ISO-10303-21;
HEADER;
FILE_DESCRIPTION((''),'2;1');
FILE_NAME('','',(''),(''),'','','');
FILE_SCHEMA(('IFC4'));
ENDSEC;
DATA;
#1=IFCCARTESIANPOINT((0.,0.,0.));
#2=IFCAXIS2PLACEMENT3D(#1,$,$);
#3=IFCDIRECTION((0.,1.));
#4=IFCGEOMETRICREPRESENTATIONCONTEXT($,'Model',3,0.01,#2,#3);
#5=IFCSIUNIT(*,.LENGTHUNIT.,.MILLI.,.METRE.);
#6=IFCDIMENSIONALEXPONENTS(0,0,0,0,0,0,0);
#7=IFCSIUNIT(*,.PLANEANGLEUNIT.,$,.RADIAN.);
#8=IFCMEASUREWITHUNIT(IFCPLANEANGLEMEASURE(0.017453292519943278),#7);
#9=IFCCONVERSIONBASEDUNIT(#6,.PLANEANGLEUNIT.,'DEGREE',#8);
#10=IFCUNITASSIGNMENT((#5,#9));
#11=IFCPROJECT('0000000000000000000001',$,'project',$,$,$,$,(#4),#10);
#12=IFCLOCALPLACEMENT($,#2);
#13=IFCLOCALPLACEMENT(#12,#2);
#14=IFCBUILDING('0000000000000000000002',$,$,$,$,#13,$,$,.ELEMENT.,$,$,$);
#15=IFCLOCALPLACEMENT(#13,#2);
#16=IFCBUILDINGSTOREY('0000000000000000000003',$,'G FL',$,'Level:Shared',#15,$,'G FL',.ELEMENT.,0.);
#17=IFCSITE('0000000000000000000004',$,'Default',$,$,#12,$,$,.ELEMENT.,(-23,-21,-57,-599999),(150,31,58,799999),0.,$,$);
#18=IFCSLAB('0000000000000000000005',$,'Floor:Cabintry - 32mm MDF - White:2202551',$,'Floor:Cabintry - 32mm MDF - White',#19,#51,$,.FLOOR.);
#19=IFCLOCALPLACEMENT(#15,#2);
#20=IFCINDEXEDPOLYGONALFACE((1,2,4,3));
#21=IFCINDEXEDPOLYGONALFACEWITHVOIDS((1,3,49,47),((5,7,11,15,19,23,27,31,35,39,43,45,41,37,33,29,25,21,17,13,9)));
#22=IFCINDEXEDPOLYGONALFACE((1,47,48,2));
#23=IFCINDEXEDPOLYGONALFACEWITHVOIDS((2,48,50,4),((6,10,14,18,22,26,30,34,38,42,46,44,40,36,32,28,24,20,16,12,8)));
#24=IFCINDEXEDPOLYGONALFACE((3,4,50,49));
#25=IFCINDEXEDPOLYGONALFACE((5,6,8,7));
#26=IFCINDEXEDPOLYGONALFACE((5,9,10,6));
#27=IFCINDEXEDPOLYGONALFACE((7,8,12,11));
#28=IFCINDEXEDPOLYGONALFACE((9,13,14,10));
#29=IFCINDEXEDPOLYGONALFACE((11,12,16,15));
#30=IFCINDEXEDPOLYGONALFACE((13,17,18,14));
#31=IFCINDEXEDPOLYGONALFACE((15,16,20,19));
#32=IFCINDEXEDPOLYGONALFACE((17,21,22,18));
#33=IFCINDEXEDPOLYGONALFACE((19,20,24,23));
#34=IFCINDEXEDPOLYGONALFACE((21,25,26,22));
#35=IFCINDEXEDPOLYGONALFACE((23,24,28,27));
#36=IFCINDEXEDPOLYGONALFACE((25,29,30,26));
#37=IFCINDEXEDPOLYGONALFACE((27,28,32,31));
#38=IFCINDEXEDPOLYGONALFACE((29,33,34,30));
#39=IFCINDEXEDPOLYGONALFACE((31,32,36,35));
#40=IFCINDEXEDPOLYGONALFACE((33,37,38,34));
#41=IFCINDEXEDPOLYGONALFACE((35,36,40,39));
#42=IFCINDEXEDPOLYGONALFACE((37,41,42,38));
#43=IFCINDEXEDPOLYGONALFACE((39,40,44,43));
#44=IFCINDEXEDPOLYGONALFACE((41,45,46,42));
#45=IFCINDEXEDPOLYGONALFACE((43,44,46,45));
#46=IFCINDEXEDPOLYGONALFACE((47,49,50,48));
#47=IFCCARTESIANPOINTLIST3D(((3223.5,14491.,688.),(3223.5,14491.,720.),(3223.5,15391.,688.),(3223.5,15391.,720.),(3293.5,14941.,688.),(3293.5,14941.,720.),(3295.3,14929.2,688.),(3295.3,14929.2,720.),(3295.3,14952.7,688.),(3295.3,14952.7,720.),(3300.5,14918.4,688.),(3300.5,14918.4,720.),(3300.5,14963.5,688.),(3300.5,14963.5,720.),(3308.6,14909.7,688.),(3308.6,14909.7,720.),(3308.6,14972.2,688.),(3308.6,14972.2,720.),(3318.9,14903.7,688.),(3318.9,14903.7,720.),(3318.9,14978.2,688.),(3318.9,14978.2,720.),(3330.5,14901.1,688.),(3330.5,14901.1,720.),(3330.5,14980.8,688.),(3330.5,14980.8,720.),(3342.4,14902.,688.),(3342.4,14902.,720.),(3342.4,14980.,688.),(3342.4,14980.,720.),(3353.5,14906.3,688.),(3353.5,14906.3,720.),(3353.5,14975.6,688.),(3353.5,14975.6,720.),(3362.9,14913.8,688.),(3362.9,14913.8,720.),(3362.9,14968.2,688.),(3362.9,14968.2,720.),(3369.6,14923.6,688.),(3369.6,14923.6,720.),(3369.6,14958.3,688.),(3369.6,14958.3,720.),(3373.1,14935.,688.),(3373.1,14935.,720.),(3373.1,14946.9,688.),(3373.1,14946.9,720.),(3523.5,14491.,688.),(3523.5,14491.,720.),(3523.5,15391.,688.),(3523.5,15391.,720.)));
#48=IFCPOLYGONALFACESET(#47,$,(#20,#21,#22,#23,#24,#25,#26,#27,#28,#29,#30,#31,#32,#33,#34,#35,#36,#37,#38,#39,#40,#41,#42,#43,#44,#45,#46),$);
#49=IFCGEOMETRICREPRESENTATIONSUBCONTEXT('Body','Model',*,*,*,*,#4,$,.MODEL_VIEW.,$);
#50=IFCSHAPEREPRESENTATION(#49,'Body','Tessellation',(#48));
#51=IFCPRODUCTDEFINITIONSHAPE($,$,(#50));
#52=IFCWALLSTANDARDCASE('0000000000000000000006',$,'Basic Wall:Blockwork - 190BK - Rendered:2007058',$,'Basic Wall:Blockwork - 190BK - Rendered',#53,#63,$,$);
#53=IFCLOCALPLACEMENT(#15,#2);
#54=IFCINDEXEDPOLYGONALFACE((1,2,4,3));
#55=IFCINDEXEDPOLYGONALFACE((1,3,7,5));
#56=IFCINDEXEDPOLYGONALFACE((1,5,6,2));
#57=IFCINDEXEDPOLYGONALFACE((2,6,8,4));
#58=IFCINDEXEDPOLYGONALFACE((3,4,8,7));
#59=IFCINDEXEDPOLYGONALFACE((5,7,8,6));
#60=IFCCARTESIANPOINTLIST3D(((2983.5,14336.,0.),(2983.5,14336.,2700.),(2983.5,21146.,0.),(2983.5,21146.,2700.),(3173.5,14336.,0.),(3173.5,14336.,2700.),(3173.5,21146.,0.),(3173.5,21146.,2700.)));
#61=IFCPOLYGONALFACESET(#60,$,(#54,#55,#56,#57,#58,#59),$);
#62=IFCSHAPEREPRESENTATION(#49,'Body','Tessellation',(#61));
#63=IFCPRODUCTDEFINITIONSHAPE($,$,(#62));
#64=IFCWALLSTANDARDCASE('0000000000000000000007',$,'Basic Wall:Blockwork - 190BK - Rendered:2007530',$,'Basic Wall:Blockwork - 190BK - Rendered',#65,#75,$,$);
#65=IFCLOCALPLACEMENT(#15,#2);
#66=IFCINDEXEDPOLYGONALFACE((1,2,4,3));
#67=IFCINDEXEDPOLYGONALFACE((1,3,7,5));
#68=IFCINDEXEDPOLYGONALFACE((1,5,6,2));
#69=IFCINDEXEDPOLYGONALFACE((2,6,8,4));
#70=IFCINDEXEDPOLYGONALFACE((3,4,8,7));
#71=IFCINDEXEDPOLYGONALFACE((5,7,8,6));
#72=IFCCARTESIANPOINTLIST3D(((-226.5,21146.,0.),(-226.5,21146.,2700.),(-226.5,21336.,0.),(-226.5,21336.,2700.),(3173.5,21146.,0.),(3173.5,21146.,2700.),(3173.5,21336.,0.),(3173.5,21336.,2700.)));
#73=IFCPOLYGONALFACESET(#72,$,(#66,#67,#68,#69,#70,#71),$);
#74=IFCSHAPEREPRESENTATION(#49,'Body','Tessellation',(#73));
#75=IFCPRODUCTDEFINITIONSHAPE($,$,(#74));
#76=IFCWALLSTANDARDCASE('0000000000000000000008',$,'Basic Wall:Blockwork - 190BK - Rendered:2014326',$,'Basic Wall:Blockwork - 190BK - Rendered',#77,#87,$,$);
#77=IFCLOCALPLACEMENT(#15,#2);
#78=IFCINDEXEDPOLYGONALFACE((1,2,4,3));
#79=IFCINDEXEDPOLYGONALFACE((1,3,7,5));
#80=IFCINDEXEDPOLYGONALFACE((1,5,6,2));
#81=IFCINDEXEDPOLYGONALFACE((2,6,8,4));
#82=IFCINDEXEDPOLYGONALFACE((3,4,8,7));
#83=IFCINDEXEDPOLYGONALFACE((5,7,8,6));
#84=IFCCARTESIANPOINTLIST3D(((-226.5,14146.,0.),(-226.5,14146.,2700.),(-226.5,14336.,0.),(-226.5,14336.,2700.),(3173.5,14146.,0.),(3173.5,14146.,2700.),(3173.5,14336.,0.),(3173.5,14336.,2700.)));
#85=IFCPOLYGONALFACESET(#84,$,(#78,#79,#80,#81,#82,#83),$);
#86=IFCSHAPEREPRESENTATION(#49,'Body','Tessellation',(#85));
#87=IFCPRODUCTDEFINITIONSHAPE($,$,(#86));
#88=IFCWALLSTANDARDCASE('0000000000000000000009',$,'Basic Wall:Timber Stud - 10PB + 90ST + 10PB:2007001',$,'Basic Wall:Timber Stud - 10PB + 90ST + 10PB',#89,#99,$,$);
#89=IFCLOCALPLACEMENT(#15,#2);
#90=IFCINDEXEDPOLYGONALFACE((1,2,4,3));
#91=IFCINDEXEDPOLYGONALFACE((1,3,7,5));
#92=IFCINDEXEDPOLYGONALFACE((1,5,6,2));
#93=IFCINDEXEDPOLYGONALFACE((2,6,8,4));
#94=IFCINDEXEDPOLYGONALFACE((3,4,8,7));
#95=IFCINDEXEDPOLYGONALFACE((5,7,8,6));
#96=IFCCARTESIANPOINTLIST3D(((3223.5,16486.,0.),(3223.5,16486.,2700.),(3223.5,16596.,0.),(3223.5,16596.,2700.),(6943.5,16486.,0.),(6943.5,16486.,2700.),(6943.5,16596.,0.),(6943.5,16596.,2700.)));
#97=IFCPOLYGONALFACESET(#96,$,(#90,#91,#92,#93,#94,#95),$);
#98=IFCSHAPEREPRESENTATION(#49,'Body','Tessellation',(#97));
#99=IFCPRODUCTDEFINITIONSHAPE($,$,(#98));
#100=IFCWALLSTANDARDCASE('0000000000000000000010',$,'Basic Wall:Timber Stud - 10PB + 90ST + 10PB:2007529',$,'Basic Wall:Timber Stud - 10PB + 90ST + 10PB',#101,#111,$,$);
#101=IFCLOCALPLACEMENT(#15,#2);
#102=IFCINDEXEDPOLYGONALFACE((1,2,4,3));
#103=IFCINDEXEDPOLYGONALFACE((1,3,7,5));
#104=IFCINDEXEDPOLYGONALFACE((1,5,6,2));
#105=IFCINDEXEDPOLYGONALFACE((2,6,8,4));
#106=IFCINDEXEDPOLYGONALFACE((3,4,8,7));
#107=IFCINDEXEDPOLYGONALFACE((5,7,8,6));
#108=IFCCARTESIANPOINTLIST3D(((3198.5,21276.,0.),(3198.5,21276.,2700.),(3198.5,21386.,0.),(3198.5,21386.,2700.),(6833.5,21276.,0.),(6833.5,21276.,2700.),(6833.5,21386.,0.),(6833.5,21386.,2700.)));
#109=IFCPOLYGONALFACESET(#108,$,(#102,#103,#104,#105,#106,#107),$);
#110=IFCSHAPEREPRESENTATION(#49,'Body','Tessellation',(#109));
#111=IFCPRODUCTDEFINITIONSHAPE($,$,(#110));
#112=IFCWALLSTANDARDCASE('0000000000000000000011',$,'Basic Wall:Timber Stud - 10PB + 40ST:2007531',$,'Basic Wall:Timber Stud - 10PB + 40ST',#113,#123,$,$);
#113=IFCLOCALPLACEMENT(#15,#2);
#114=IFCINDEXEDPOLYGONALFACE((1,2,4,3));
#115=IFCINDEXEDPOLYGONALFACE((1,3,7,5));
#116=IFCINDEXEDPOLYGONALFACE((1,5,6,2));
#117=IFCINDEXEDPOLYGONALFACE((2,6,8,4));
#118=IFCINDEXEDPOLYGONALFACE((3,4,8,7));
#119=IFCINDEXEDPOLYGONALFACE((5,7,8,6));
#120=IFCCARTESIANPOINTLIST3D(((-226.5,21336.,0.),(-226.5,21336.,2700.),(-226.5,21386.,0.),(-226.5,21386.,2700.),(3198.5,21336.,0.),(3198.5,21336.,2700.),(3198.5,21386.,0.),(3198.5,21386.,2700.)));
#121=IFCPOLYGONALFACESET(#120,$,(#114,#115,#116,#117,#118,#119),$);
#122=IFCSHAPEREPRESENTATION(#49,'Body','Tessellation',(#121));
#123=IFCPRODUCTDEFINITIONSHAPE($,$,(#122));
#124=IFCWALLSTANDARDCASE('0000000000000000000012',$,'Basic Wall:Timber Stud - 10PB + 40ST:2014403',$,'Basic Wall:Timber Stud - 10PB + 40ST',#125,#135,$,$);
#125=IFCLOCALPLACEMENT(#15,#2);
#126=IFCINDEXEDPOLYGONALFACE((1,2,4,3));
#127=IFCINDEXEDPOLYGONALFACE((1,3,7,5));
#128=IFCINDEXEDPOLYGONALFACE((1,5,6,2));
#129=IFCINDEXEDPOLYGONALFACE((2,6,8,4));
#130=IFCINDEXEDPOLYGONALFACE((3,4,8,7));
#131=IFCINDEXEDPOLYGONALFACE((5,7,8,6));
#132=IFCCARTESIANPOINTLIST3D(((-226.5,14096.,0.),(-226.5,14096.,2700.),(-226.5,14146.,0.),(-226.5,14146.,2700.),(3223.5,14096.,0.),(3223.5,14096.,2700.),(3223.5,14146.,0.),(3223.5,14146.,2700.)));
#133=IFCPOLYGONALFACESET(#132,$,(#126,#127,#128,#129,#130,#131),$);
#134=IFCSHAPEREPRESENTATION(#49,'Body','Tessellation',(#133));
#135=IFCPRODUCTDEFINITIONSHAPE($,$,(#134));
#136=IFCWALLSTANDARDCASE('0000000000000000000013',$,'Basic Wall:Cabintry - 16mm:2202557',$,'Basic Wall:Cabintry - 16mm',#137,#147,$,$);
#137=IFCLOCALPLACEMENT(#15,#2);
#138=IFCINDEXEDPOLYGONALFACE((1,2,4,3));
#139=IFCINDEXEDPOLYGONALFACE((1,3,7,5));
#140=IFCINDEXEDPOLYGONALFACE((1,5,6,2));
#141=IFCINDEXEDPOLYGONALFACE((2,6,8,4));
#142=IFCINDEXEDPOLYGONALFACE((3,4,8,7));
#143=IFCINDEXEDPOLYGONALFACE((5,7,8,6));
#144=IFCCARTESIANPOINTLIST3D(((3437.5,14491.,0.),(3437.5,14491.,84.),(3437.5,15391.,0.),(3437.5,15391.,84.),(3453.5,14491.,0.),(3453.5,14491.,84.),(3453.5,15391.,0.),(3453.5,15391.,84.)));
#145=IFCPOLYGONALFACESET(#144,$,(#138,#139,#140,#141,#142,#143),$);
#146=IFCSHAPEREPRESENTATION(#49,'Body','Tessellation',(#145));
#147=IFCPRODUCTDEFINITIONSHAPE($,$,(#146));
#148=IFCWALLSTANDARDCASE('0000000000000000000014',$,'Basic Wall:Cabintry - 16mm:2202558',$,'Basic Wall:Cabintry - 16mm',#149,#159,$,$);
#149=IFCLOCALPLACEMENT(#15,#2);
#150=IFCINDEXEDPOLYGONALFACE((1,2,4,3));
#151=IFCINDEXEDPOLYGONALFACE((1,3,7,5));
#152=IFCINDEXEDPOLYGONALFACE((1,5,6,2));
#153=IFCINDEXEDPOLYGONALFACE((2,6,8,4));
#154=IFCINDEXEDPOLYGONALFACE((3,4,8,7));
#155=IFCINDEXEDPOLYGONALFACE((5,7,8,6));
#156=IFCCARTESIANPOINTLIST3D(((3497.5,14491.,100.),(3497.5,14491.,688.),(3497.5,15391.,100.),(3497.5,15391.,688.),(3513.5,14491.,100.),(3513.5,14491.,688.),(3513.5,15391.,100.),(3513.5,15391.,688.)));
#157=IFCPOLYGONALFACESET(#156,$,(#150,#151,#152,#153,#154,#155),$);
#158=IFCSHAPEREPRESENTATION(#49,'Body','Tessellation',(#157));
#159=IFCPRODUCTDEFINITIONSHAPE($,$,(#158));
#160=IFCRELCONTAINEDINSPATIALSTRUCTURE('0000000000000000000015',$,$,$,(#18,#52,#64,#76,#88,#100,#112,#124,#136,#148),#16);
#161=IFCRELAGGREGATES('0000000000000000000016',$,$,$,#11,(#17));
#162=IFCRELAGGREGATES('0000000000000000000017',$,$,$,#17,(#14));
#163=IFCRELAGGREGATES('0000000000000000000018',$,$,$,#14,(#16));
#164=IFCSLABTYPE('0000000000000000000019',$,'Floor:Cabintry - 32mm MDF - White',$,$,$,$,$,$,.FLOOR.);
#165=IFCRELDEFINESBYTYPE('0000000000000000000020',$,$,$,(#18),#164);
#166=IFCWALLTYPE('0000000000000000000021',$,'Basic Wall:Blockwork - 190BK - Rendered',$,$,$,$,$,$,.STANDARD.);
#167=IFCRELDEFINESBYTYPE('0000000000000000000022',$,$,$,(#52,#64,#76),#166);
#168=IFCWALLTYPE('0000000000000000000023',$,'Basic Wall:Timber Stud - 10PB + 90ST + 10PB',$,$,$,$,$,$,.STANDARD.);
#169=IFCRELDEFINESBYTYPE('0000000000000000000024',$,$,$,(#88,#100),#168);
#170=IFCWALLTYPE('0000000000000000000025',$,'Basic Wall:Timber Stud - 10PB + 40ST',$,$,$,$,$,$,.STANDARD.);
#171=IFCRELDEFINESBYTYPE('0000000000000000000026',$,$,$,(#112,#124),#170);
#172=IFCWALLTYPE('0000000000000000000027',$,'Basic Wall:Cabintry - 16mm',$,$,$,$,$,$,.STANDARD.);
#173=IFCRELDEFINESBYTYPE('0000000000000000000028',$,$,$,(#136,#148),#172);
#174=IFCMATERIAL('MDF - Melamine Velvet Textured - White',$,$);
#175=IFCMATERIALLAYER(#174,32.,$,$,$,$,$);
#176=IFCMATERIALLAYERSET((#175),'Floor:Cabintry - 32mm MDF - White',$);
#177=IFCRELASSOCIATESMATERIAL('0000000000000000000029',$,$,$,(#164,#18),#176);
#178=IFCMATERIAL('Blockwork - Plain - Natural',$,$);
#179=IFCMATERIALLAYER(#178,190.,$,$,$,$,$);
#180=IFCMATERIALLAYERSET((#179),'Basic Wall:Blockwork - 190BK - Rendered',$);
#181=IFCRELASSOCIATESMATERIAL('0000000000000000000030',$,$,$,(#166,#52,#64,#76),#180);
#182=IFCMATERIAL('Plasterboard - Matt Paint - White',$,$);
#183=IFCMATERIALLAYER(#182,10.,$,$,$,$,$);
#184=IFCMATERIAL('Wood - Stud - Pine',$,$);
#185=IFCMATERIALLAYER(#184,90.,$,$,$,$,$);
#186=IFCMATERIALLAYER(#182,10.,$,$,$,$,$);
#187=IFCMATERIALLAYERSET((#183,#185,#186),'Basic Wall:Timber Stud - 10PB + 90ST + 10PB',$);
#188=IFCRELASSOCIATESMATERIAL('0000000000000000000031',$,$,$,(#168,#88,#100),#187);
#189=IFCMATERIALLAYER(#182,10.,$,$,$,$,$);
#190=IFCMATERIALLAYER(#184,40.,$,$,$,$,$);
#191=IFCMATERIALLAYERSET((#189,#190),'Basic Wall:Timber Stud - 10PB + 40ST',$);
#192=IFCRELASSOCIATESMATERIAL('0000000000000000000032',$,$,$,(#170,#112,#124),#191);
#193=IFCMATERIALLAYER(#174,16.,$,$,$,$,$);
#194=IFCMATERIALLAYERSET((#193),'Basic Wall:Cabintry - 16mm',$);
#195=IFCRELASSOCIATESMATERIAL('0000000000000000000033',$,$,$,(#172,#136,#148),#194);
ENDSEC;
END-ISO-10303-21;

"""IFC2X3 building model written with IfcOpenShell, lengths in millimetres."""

from ifc_helpers import new_model, entity, si_unit, converted_unit, direction, frame, frame_2d, origin, origin_2d_with_axis, place, context, subcontext, project, spatial, polyline, rectangle, circle, extrude, clip, bounded_halfspace, material, layer, layer_set, layer_usage, type_object, element, save


model = new_model("IFC2X3")

# Units and contexts
model_context = context("Model", 3, precision=0.01, world=origin(), true_north=direction((0.0, 1.0)))
body_context = subcontext(model_context, "Body", "Model", "MODEL_VIEW")
ifc_project = project(units=[si_unit("LENGTHUNIT", "METRE", prefix="MILLI"), converted_unit("PLANEANGLEUNIT", "DEGREE", entity("IfcPlaneAngleMeasure", 0.017453292519943278), si_unit("PLANEANGLEUNIT", "RADIAN"), dimensions=[0, 0, 0, 0, 0, 0, 0])], contexts=[model_context])

# Site, building, storey
site_placement = place(None, origin())
site = spatial("IfcSite", under=ifc_project, at=site_placement, Name="Default", CompositionType="ELEMENT", RefLatitude=(-23, -21, -57, -599999), RefLongitude=(150, 31, 58, 799999), RefElevation=0.0)
building_placement = place(site_placement, origin())
building = spatial("IfcBuilding", under=site, at=building_placement, CompositionType="ELEMENT")
storey_placement = place(building_placement, origin())
storey = spatial("IfcBuildingStorey", under=building, at=storey_placement, Name="G FL", ObjectType="Level:Shared", LongName="G FL", CompositionType="ELEMENT", Elevation=0.0)

# Slab, opening
ifc_material_1 = material(Name="MDF - Melamine Velvet Textured - White")
ifc_layer_1 = layer(ifc_material_1, 32.0)
ifc_layer_set_1 = layer_set([ifc_layer_1], Name="Floor:Cabintry - 32mm MDF - White")
ifc_layer_usage_1 = layer_usage(ifc_layer_set_1, "AXIS3", "POSITIVE", 0.0)
slab_type = type_object("IfcSlabType", Name="Floor:Cabintry - 32mm MDF - White", PredefinedType="FLOOR", material=ifc_layer_set_1)
slab_placement = place(storey_placement, frame((3223.5, 14491.0, 688.0)))
slab = element("IfcSlab", 1, at=slab_placement, inside=storey, type_object=slab_type, material=ifc_layer_usage_1, Name="Floor:Cabintry - 32mm MDF - White:2202551", ObjectType="Floor:Cabintry - 32mm MDF - White", PredefinedType="FLOOR", context=body_context, shape_type="SweptSolid", body=[
    extrude(rectangle(XDim=300.0, YDim=900.0, at=origin_2d_with_axis()), frame((150.0, 450.0, 32.0), z_axis=(0.0, 0.0, -1.0), x_axis=(-1.0, 0.0, 0.0)), (0.0, 0.0, 1.0), 32.0),
])
opening_1_placement = place(slab_placement, origin())
element("IfcOpeningElement", 2, at=opening_1_placement, cuts=slab, ObjectType="Opening", context=body_context, shape_type="SweptSolid", body=[
    extrude(circle(Radius=40.0, at=frame_2d((40.0, 0.0), x_axis=(1.0, 0.0))), frame((150.0, 450.0, 32.0), z_axis=(0.0, 0.0, -1.0), x_axis=(-1.0, 0.0, 0.0)), (0.0, 0.0, 1.0), 32.0),
])

# Walls
ifc_material_2 = material(Name="Blockwork - Plain - Natural")
ifc_layer_2 = layer(ifc_material_2, 190.0)
ifc_layer_set_2 = layer_set([ifc_layer_2], Name="Basic Wall:Blockwork - 190BK - Rendered")
ifc_layer_usage_2 = layer_usage(ifc_layer_set_2, "AXIS2", "NEGATIVE", 95.0)
wall_type_1 = type_object("IfcWallType", Name="Basic Wall:Blockwork - 190BK - Rendered", PredefinedType="STANDARD", material=ifc_layer_set_2)
wall_1_placement = place(storey_placement, frame((3078.5, 14336.0, 0.0), z_axis=(0.0, 0.0, 1.0), x_axis=(0.0, 1.0, 0.0)))
element("IfcWallStandardCase", 3, at=wall_1_placement, inside=storey, type_object=wall_type_1, material=ifc_layer_usage_2, Name="Basic Wall:Blockwork - 190BK - Rendered:2007058", ObjectType="Basic Wall:Blockwork - 190BK - Rendered", context=body_context, shape_type="SweptSolid", body=[
    extrude(rectangle(XDim=6810.0, YDim=190.0, at=frame_2d((3405.0, 0.0), x_axis=(-1.0, 0.0))), origin(), (0.0, 0.0, 1.0), 2700.0),
])
ifc_layer_usage_3 = layer_usage(ifc_layer_set_2, "AXIS2", "NEGATIVE", 95.0)
wall_2_placement = place(storey_placement, frame((3173.5, 21241.0, 0.0), z_axis=(0.0, 0.0, 1.0), x_axis=(-1.0, 0.0, 0.0)))
element("IfcWallStandardCase", 4, at=wall_2_placement, inside=storey, type_object=wall_type_1, material=ifc_layer_usage_3, Name="Basic Wall:Blockwork - 190BK - Rendered:2007530", ObjectType="Basic Wall:Blockwork - 190BK - Rendered", context=body_context, shape_type="SweptSolid", body=[
    extrude(rectangle(XDim=3400.0, YDim=190.0, at=frame_2d((1700.0, 0.0), x_axis=(-1.0, 0.0))), origin(), (0.0, 0.0, 1.0), 2700.0),
])
ifc_layer_usage_4 = layer_usage(ifc_layer_set_2, "AXIS2", "NEGATIVE", 95.0)
wall_3_placement = place(storey_placement, frame((-226.5, 14241.0, 0.0)))
element("IfcWallStandardCase", 5, at=wall_3_placement, inside=storey, type_object=wall_type_1, material=ifc_layer_usage_4, Name="Basic Wall:Blockwork - 190BK - Rendered:2014326", ObjectType="Basic Wall:Blockwork - 190BK - Rendered", context=body_context, shape_type="SweptSolid", body=[
    extrude(rectangle(XDim=3400.0, YDim=190.0, at=frame_2d((1700.0, 0.0), x_axis=(-1.0, 0.0))), origin(), (0.0, 0.0, 1.0), 2700.0),
])
ifc_material_3 = material(Name="Plasterboard - Matt Paint - White")
ifc_layer_3 = layer(ifc_material_3, 10.0)
ifc_material_4 = material(Name="Wood - Stud - Pine")
ifc_layer_4 = layer(ifc_material_4, 90.0)
ifc_layer_5 = layer(ifc_material_3, 10.0)
ifc_layer_set_3 = layer_set([ifc_layer_3, ifc_layer_4, ifc_layer_5], Name="Basic Wall:Timber Stud - 10PB + 90ST + 10PB")
ifc_layer_usage_5 = layer_usage(ifc_layer_set_3, "AXIS2", "NEGATIVE", 55.0)
wall_type_2 = type_object("IfcWallType", Name="Basic Wall:Timber Stud - 10PB + 90ST + 10PB", PredefinedType="STANDARD", material=ifc_layer_set_3)
wall_4_placement = place(storey_placement, frame((3223.5, 16541.0, 0.0)))
element("IfcWallStandardCase", 6, at=wall_4_placement, inside=storey, type_object=wall_type_2, material=ifc_layer_usage_5, Name="Basic Wall:Timber Stud - 10PB + 90ST + 10PB:2007001", ObjectType="Basic Wall:Timber Stud - 10PB + 90ST + 10PB", context=body_context, shape_type="SweptSolid", body=[
    extrude(rectangle(XDim=3720.0, YDim=110.0, at=frame_2d((1860.0, 0.0), x_axis=(-1.0, 0.0))), origin(), (0.0, 0.0, 1.0), 2700.0),
])
ifc_layer_usage_6 = layer_usage(ifc_layer_set_3, "AXIS2", "NEGATIVE", 55.0)
wall_5_placement = place(storey_placement, frame((6833.5, 21331.0, 0.0), z_axis=(0.0, 0.0, 1.0), x_axis=(-1.0, 0.0, 0.0)))
element("IfcWallStandardCase", 7, at=wall_5_placement, inside=storey, type_object=wall_type_2, material=ifc_layer_usage_6, Name="Basic Wall:Timber Stud - 10PB + 90ST + 10PB:2007529", ObjectType="Basic Wall:Timber Stud - 10PB + 90ST + 10PB", context=body_context, shape_type="SweptSolid", body=[
    extrude(rectangle(XDim=3635.0, YDim=110.0, at=frame_2d((1817.5, 0.0), x_axis=(-1.0, 0.0))), origin(), (0.0, 0.0, 1.0), 2700.0),
])
ifc_layer_6 = layer(ifc_material_3, 10.0)
ifc_layer_7 = layer(ifc_material_4, 40.0)
ifc_layer_set_4 = layer_set([ifc_layer_6, ifc_layer_7], Name="Basic Wall:Timber Stud - 10PB + 40ST")
wall_type_3 = type_object("IfcWallType", Name="Basic Wall:Timber Stud - 10PB + 40ST", PredefinedType="STANDARD", material=ifc_layer_set_4)
ifc_layer_usage_7 = layer_usage(ifc_layer_set_4, "AXIS2", "NEGATIVE", 25.0)
wall_6_placement = place(storey_placement, frame((-226.5, 21361.0, 0.0)))
element("IfcWallStandardCase", 8, at=wall_6_placement, inside=storey, type_object=wall_type_3, material=ifc_layer_usage_7, Name="Basic Wall:Timber Stud - 10PB + 40ST:2007531", ObjectType="Basic Wall:Timber Stud - 10PB + 40ST", context=body_context, shape_type="SweptSolid", body=[
    extrude(rectangle(XDim=3425.0, YDim=50.0, at=frame_2d((1712.5, 0.0), x_axis=(-1.0, 0.0))), origin(), (0.0, 0.0, 1.0), 2700.0),
])
ifc_layer_usage_8 = layer_usage(ifc_layer_set_4, "AXIS2", "NEGATIVE", 25.0)
wall_7_placement = place(storey_placement, frame((3223.5, 14121.0, 0.0), z_axis=(0.0, 0.0, 1.0), x_axis=(-1.0, 0.0, 0.0)))
element("IfcWallStandardCase", 9, at=wall_7_placement, inside=storey, type_object=wall_type_3, material=ifc_layer_usage_8, Name="Basic Wall:Timber Stud - 10PB + 40ST:2014403", ObjectType="Basic Wall:Timber Stud - 10PB + 40ST", context=body_context, shape_type="SweptSolid", body=[
    extrude(rectangle(XDim=3450.0, YDim=50.0, at=frame_2d((1725.0, 0.0), x_axis=(-1.0, 0.0))), origin(), (0.0, 0.0, 1.0), 2700.0),
])
ifc_layer_8 = layer(ifc_material_1, 16.0)
ifc_layer_set_5 = layer_set([ifc_layer_8], Name="Basic Wall:Cabintry - 16mm")
ifc_layer_usage_9 = layer_usage(ifc_layer_set_5, "AXIS2", "POSITIVE", -8.0)
wall_type_4 = type_object("IfcWallType", Name="Basic Wall:Cabintry - 16mm", PredefinedType="STANDARD", material=ifc_layer_set_5)
wall_8_placement = place(storey_placement, frame((3445.5, 15391.0, 0.0), z_axis=(0.0, 0.0, 1.0), x_axis=(0.0, -1.0, 0.0)))
element("IfcWallStandardCase", 10, at=wall_8_placement, inside=storey, type_object=wall_type_4, material=ifc_layer_usage_9, Name="Basic Wall:Cabintry - 16mm:2202557", ObjectType="Basic Wall:Cabintry - 16mm", context=body_context, shape_type="Clipping", body=[
    clip(extrude(rectangle(XDim=900.0, YDim=16.0, at=frame_2d((450.0, 0.0), x_axis=(-1.0, 0.0))), origin(), (0.0, 0.0, 1.0), 84.0), bounded_halfspace(frame((0.0, -8.0, 84.0), z_axis=(0.0, 0.0, -1.0), x_axis=(0.0, -1.0, 0.0)), True, frame((0.0, -8.0, 84.0)), polyline([(0.0, 0.0), (884.0, 0.0), (900.0, 0.0), (900.0, 16.0), (0.0, 16.0), (0.0, 0.0)]))),
])
ifc_layer_usage_10 = layer_usage(ifc_layer_set_5, "AXIS2", "POSITIVE", -8.0)
wall_9_placement = place(storey_placement, frame((3505.5, 15391.0, 100.0), z_axis=(0.0, 0.0, 1.0), x_axis=(0.0, -1.0, 0.0)))
element("IfcWallStandardCase", 11, at=wall_9_placement, inside=storey, type_object=wall_type_4, material=ifc_layer_usage_10, Name="Basic Wall:Cabintry - 16mm:2202558", ObjectType="Basic Wall:Cabintry - 16mm", context=body_context, shape_type="SweptSolid", body=[
    extrude(rectangle(XDim=900.0, YDim=16.0, at=frame_2d((450.0, 0.0), x_axis=(-1.0, 0.0))), origin(), (0.0, 0.0, 1.0), 588.0),
])

save(model, "model.ifc")
